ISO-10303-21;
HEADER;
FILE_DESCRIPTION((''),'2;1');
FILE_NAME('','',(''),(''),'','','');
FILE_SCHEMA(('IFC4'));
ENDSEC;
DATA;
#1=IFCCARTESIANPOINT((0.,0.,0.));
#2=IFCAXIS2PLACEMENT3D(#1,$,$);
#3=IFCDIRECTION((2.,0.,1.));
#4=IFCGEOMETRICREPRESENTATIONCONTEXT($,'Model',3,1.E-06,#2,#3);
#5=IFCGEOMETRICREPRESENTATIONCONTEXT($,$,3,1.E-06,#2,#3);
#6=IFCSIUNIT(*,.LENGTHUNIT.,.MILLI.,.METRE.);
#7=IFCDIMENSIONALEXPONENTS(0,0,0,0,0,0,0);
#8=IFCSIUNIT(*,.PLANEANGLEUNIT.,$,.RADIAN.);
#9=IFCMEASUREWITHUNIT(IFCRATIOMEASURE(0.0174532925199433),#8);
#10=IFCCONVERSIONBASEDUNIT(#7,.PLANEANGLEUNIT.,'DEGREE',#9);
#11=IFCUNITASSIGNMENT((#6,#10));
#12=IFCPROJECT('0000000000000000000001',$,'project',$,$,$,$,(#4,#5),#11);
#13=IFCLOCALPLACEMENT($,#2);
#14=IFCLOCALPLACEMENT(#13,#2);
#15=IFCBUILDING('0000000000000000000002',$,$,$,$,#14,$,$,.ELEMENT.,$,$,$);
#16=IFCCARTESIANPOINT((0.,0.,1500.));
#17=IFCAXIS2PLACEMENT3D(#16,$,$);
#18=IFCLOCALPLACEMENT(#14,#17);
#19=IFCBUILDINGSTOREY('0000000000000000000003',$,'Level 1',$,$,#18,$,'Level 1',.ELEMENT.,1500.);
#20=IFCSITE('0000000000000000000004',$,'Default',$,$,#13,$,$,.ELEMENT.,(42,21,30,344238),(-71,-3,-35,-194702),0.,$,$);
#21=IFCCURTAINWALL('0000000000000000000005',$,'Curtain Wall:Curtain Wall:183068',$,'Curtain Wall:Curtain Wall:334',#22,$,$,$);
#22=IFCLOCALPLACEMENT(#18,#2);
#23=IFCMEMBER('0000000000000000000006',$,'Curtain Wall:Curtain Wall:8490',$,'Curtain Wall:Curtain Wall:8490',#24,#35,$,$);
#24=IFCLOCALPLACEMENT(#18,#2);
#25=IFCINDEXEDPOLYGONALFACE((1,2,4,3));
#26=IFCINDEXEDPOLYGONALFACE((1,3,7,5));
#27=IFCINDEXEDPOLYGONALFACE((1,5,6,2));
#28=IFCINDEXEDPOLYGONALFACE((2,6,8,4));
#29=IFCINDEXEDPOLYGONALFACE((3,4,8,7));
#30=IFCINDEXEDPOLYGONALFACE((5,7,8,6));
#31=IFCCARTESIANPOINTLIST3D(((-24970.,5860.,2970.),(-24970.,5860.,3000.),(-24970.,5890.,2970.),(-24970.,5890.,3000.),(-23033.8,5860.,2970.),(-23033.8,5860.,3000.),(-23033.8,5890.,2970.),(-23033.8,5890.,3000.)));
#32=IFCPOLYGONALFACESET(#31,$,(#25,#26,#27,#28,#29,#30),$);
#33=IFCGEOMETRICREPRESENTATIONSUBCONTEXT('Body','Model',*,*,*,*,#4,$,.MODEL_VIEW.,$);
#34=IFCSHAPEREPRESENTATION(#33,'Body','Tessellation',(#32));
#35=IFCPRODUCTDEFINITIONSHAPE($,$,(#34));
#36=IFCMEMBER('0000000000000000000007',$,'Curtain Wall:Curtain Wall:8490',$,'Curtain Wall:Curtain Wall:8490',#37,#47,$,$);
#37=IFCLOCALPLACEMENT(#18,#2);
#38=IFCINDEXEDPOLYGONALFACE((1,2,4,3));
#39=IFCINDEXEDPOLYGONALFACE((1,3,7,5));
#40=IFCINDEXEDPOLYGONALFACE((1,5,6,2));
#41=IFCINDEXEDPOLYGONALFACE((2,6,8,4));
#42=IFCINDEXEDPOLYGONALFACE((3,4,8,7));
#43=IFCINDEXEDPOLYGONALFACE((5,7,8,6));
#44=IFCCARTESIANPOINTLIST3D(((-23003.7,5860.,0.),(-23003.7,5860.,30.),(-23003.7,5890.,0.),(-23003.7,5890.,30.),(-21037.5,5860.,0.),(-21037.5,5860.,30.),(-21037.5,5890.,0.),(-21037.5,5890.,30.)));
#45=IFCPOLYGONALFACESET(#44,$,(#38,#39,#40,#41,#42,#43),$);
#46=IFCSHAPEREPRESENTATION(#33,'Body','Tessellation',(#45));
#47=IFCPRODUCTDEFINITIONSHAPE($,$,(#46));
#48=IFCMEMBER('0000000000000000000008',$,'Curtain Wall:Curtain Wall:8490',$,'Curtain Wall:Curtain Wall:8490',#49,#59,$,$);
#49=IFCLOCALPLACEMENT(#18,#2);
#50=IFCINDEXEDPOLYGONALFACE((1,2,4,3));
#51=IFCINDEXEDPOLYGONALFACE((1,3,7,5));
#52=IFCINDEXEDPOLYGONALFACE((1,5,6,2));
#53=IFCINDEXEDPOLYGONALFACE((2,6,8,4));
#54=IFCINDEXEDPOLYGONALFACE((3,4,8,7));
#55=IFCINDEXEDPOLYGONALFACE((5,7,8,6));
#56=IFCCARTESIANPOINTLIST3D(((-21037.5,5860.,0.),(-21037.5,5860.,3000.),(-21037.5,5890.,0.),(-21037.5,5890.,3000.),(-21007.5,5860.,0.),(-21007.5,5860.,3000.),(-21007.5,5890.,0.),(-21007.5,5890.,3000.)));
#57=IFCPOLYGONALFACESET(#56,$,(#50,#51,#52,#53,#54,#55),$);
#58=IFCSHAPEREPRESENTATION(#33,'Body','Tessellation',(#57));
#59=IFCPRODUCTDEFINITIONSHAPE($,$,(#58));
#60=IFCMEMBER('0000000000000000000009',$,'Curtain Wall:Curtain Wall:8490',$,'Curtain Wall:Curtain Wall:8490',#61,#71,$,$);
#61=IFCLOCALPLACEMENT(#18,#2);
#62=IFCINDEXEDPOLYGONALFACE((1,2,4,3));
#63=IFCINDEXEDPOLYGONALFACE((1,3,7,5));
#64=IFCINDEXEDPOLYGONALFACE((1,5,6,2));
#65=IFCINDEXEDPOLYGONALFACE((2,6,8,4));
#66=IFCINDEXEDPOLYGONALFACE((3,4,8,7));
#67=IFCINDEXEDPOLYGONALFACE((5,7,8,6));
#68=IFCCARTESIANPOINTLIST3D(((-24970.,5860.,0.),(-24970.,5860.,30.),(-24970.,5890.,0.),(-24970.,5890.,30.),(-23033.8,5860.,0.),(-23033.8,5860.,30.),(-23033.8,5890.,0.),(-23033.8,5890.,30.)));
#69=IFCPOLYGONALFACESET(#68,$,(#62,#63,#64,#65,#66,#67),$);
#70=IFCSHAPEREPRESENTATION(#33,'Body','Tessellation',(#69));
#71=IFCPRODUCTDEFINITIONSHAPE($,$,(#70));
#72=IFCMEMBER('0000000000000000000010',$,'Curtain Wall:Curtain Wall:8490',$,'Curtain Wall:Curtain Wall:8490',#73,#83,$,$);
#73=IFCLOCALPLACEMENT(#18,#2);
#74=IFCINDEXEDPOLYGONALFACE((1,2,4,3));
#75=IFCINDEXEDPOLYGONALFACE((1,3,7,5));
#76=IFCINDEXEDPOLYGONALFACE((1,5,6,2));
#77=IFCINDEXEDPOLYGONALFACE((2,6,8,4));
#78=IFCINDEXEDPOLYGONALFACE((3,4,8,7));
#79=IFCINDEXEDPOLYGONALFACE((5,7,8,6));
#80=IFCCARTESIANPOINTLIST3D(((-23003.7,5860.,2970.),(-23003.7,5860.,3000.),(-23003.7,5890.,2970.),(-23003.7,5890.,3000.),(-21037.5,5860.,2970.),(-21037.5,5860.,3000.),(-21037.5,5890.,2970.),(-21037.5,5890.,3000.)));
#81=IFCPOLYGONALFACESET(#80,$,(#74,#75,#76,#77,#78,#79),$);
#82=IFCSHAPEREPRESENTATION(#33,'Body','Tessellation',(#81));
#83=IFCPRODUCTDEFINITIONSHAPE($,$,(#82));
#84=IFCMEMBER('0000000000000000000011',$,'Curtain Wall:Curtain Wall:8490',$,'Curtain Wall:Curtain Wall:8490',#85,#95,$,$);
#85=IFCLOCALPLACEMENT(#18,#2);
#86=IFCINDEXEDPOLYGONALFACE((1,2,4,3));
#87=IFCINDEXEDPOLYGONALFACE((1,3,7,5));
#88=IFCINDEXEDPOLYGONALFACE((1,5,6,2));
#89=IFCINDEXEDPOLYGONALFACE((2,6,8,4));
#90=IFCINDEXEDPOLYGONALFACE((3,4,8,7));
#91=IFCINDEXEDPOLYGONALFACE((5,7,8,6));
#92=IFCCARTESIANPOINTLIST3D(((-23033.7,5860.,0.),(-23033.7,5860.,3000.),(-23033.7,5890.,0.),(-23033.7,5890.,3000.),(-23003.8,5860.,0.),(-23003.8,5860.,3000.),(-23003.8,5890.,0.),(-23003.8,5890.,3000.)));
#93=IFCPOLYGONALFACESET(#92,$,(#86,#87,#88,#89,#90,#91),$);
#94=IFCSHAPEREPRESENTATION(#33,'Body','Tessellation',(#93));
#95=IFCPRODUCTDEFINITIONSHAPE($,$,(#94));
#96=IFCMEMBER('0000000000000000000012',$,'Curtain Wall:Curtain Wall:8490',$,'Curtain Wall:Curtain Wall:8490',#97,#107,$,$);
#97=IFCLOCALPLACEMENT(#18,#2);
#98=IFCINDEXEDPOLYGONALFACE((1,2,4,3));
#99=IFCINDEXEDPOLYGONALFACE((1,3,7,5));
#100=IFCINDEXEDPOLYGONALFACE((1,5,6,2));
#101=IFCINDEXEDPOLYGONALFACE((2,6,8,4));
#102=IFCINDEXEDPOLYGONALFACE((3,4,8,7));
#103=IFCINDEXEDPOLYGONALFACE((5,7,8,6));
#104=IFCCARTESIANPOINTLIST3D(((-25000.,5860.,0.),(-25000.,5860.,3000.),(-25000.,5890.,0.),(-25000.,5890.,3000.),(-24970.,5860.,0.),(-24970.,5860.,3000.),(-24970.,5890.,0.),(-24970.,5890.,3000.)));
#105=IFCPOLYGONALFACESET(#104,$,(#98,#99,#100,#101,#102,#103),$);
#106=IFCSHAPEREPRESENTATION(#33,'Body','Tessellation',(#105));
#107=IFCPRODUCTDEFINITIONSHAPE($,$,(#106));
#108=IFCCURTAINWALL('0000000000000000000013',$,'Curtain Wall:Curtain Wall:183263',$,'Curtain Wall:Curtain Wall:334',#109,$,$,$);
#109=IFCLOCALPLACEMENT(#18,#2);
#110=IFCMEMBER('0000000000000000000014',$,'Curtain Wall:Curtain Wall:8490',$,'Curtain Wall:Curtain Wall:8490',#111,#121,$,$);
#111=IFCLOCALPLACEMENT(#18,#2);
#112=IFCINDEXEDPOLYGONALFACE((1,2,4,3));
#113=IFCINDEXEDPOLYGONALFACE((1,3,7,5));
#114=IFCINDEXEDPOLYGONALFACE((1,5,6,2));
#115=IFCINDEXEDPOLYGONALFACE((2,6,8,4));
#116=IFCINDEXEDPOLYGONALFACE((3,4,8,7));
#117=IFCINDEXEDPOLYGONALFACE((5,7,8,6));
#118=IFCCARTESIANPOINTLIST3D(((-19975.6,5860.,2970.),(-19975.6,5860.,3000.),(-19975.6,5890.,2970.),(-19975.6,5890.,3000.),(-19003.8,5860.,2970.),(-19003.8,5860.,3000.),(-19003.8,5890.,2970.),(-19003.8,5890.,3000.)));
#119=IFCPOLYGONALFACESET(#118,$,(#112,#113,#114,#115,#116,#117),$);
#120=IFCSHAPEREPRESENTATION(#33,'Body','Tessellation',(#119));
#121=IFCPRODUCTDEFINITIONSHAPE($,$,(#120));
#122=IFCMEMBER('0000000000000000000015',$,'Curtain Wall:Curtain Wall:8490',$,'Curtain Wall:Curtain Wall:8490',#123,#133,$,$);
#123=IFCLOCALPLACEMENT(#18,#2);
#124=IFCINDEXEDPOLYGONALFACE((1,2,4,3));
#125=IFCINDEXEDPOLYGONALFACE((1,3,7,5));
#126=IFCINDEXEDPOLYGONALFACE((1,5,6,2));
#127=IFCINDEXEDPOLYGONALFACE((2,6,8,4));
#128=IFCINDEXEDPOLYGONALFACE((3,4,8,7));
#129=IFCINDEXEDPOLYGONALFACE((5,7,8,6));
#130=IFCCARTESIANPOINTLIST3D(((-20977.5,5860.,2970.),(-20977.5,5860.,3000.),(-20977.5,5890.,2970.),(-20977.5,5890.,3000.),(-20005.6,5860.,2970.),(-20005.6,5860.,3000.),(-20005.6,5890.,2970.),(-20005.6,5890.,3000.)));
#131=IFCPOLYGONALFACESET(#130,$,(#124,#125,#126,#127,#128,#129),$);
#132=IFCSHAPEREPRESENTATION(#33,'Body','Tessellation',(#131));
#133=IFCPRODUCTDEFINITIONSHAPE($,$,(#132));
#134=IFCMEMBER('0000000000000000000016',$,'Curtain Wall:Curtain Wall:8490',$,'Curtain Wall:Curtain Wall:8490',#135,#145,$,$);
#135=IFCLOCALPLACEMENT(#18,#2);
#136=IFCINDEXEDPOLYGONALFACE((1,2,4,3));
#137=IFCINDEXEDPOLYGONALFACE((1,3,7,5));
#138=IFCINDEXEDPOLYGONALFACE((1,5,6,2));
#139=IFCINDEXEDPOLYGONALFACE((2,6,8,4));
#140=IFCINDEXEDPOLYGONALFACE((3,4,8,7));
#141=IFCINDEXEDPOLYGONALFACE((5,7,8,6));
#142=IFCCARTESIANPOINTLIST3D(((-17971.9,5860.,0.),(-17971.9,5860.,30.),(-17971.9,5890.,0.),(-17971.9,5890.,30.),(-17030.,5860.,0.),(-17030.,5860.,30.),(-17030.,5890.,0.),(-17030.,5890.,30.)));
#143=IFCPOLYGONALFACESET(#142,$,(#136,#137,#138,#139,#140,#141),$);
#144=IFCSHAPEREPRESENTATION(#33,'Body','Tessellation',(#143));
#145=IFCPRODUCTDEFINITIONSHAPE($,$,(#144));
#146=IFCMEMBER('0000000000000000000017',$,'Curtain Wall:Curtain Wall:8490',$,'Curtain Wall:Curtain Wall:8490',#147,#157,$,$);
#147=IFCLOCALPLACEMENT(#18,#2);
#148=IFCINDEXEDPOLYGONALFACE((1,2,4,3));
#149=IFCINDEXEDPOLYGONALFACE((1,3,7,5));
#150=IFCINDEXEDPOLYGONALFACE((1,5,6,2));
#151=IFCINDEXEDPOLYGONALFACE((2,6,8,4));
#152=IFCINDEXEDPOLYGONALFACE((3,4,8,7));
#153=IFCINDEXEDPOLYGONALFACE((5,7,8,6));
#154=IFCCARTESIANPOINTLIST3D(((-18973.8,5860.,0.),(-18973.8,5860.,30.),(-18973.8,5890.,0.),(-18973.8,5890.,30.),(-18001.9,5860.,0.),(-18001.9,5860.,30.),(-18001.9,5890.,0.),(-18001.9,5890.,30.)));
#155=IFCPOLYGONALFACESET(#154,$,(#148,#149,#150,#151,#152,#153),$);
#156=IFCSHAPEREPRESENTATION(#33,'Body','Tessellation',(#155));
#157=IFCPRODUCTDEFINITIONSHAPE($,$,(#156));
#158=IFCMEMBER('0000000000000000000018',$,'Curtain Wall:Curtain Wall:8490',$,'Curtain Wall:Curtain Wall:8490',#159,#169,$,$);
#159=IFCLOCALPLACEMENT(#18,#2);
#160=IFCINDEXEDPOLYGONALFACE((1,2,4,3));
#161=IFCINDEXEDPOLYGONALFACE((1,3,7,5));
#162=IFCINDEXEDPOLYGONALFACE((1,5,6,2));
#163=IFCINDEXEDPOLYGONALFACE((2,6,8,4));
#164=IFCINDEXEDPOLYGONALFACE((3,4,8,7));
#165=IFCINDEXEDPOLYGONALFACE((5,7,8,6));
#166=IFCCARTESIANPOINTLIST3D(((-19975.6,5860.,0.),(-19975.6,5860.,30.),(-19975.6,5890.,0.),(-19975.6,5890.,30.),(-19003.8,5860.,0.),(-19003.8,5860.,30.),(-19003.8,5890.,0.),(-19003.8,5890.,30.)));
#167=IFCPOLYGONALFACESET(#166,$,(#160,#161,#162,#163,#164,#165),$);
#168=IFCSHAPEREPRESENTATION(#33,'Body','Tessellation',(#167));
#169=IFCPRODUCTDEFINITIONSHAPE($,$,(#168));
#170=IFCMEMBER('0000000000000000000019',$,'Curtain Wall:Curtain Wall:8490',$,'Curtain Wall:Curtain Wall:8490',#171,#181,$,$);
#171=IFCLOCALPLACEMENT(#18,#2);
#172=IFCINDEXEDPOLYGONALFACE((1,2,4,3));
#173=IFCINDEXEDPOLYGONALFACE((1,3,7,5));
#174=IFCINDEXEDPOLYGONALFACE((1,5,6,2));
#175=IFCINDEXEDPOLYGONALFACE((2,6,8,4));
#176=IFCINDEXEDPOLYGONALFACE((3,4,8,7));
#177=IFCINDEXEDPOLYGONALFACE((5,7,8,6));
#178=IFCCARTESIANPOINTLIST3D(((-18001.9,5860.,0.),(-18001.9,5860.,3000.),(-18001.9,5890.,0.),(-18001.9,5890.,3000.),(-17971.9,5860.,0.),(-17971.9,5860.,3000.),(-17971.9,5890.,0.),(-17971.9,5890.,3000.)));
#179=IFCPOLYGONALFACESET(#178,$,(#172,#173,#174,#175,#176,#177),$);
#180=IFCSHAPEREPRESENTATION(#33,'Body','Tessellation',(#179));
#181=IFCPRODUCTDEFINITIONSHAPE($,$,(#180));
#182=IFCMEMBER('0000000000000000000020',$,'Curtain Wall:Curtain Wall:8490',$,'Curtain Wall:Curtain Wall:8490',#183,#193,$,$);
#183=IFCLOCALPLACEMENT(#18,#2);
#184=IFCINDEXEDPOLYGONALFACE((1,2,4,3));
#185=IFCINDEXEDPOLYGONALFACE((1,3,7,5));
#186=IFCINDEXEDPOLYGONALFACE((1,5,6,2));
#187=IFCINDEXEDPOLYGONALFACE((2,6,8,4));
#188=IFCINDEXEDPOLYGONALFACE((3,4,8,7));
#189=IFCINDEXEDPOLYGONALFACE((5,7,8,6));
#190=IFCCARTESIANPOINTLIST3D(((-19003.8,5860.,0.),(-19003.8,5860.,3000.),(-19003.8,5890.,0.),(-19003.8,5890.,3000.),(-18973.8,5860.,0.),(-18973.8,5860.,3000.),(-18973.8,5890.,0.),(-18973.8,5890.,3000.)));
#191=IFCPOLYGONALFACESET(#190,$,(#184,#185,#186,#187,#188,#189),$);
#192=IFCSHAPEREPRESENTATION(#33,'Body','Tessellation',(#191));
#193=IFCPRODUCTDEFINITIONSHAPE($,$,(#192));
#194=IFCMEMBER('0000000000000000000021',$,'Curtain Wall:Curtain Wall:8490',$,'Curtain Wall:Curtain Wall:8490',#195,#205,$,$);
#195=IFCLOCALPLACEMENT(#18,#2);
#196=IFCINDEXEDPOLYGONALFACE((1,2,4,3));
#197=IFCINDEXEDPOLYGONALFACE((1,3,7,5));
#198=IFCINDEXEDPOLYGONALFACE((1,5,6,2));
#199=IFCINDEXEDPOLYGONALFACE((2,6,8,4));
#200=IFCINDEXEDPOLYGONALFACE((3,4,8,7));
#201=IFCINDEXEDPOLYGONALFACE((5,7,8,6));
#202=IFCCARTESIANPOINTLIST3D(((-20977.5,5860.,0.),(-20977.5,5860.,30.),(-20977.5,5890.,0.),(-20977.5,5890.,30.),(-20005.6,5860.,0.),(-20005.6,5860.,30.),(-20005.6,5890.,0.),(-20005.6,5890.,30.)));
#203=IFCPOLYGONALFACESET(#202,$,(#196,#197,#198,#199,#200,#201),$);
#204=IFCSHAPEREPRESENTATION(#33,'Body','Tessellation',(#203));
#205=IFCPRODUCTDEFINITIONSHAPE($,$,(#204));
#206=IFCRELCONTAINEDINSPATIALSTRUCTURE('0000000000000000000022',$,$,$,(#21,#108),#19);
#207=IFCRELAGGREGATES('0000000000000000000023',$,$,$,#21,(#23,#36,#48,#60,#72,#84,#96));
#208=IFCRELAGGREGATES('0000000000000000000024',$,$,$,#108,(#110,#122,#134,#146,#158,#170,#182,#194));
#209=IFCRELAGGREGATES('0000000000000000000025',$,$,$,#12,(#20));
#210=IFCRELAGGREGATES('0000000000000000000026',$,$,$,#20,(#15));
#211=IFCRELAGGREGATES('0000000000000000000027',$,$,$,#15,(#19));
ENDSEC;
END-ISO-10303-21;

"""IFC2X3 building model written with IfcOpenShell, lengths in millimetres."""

from ifc_helpers import new_model, entity, si_unit, converted_unit, direction, frame, frame_2d, origin, origin_2d_with_axis, place, context, subcontext, project, spatial, rectangle, extrude, element, aggregate, save


model = new_model("IFC2X3")

# Units and contexts
model_context = context("Model", 3, precision=1e-06, world=origin(), true_north=direction((2.0, 0.0, 1.0)))
context_of_model = context(None, 3, precision=1e-06, world=origin(), true_north=direction((2.0, 0.0, 1.0)))
body_context = subcontext(model_context, "Body", "Model", "MODEL_VIEW")
ifc_project = project(units=[si_unit("LENGTHUNIT", "METRE", prefix="MILLI"), converted_unit("PLANEANGLEUNIT", "DEGREE", entity("IfcRatioMeasure", 0.0174532925199433), si_unit("PLANEANGLEUNIT", "RADIAN"), dimensions=[0, 0, 0, 0, 0, 0, 0])], contexts=[model_context, context_of_model])

# Site, building, storey
site_placement = place(None, origin())
site = spatial("IfcSite", under=ifc_project, at=site_placement, Name="Default", CompositionType="ELEMENT", RefLatitude=(42, 21, 30, 344238), RefLongitude=(-71, -3, -35, -194702), RefElevation=0.0)
building_placement = place(site_placement, origin())
building = spatial("IfcBuilding", under=site, at=building_placement, CompositionType="ELEMENT")
storey_placement = place(building_placement, frame((0.0, 0.0, 1500.0)))
storey = spatial("IfcBuildingStorey", under=building, at=storey_placement, Name="Level 1", LongName="Level 1", CompositionType="ELEMENT", Elevation=1500.0)

# Curtain walls, members
curtain_wall_1_placement = place(storey_placement, origin())
curtain_wall_1 = element("IfcCurtainWall", 1, at=curtain_wall_1_placement, inside=storey, Name="Curtain Wall:Curtain Wall:183068", ObjectType="Curtain Wall:Curtain Wall:334")
member_1_placement = place(storey_placement, origin())
member_1 = element("IfcMember", 2, at=member_1_placement, Name="Curtain Wall:Curtain Wall:8490", ObjectType="Curtain Wall:Curtain Wall:8490", context=body_context, shape_type="SweptSolid", body=[
    extrude(rectangle(XDim=1936.2, YDim=30.0, at=origin_2d_with_axis()), frame((-24001.9, 5875.0, 2970.0), z_axis=(0.0, 0.0, 1.0), x_axis=(-1.0, 0.0, 0.0)), (0.0, 0.0, 1.0), 30.0),
])
member_2_placement = place(storey_placement, origin())
member_2 = element("IfcMember", 3, at=member_2_placement, Name="Curtain Wall:Curtain Wall:8490", ObjectType="Curtain Wall:Curtain Wall:8490", context=body_context, shape_type="SweptSolid", body=[
    extrude(rectangle(XDim=1966.2, YDim=30.0, at=frame_2d((0.0, 0.0), x_axis=(1.0, 0.0))), frame((-22020.6, 5875.0, 0.0)), (0.0, 0.0, 1.0), 30.0),
])
member_3_placement = place(storey_placement, origin())
member_3 = element("IfcMember", 4, at=member_3_placement, Name="Curtain Wall:Curtain Wall:8490", ObjectType="Curtain Wall:Curtain Wall:8490", context=body_context, shape_type="SweptSolid", body=[
    extrude(rectangle(XDim=30.0, YDim=30.0, at=frame_2d((0.0, 0.0), x_axis=(1.0, 0.0))), frame((-21022.5, 5875.0, 0.0), z_axis=(0.0, 0.0, 1.0), x_axis=(0.0, 1.0, 0.0)), (0.0, 0.0, 1.0), 3000.0),
])
member_4_placement = place(storey_placement, origin())
member_4 = element("IfcMember", 5, at=member_4_placement, Name="Curtain Wall:Curtain Wall:8490", ObjectType="Curtain Wall:Curtain Wall:8490", context=body_context, shape_type="SweptSolid", body=[
    extrude(rectangle(XDim=1936.2, YDim=30.0, at=origin_2d_with_axis()), frame((-24001.9, 5875.0, 0.0)), (0.0, 0.0, 1.0), 30.0),
])
member_5_placement = place(storey_placement, origin())
member_5 = element("IfcMember", 6, at=member_5_placement, Name="Curtain Wall:Curtain Wall:8490", ObjectType="Curtain Wall:Curtain Wall:8490", context=body_context, shape_type="SweptSolid", body=[
    extrude(rectangle(XDim=1966.2, YDim=30.0, at=frame_2d((0.0, 0.0), x_axis=(1.0, 0.0))), frame((-22020.6, 5875.0, 2970.0), z_axis=(0.0, 0.0, 1.0), x_axis=(-1.0, 0.0, 0.0)), (0.0, 0.0, 1.0), 30.0),
])
member_6_placement = place(storey_placement, origin())
member_6 = element("IfcMember", 7, at=member_6_placement, Name="Curtain Wall:Curtain Wall:8490", ObjectType="Curtain Wall:Curtain Wall:8490", context=body_context, shape_type="SweptSolid", body=[
    extrude(rectangle(XDim=30.0, YDim=30.0, at=frame_2d((0.0, 0.0), x_axis=(1.0, 0.0))), frame((-23018.8, 5875.0, 0.0), z_axis=(0.0, 0.0, 1.0), x_axis=(0.0, 1.0, 0.0)), (0.0, 0.0, 1.0), 3000.0),
])
member_7_placement = place(storey_placement, origin())
member_7 = element("IfcMember", 8, at=member_7_placement, Name="Curtain Wall:Curtain Wall:8490", ObjectType="Curtain Wall:Curtain Wall:8490", context=body_context, shape_type="SweptSolid", body=[
    extrude(rectangle(XDim=30.0, YDim=30.0, at=origin_2d_with_axis()), frame((-24985.0, 5875.0, 0.0)), (0.0, 0.0, 1.0), 3000.0),
])
curtain_wall_2_placement = place(storey_placement, origin())
curtain_wall_2 = element("IfcCurtainWall", 9, at=curtain_wall_2_placement, inside=storey, Name="Curtain Wall:Curtain Wall:183263", ObjectType="Curtain Wall:Curtain Wall:334")
member_8_placement = place(storey_placement, origin())
member_8 = element("IfcMember", 10, at=member_8_placement, Name="Curtain Wall:Curtain Wall:8490", ObjectType="Curtain Wall:Curtain Wall:8490", context=body_context, shape_type="SweptSolid", body=[
    extrude(rectangle(XDim=971.9, YDim=30.0, at=frame_2d((0.0, 0.0), x_axis=(1.0, 0.0))), frame((-19489.7, 5875.0, 2970.0), z_axis=(0.0, 0.0, 1.0), x_axis=(-1.0, 0.0, 0.0)), (0.0, 0.0, 1.0), 30.0),
])
member_9_placement = place(storey_placement, origin())
member_9 = element("IfcMember", 11, at=member_9_placement, Name="Curtain Wall:Curtain Wall:8490", ObjectType="Curtain Wall:Curtain Wall:8490", context=body_context, shape_type="SweptSolid", body=[
    extrude(rectangle(XDim=971.9, YDim=30.0, at=frame_2d((0.0, 0.0), x_axis=(1.0, 0.0))), frame((-20491.6, 5875.0, 2970.0), z_axis=(0.0, 0.0, 1.0), x_axis=(-1.0, 0.0, 0.0)), (0.0, 0.0, 1.0), 30.0),
])
member_10_placement = place(storey_placement, origin())
member_10 = element("IfcMember", 12, at=member_10_placement, Name="Curtain Wall:Curtain Wall:8490", ObjectType="Curtain Wall:Curtain Wall:8490", context=body_context, shape_type="SweptSolid", body=[
    extrude(rectangle(XDim=941.9, YDim=30.0, at=frame_2d((0.0, 0.0), x_axis=(1.0, 0.0))), frame((-17500.9, 5875.0, 0.0)), (0.0, 0.0, 1.0), 30.0),
])
member_11_placement = place(storey_placement, origin())
member_11 = element("IfcMember", 13, at=member_11_placement, Name="Curtain Wall:Curtain Wall:8490", ObjectType="Curtain Wall:Curtain Wall:8490", context=body_context, shape_type="SweptSolid", body=[
    extrude(rectangle(XDim=971.9, YDim=30.0, at=frame_2d((0.0, 0.0), x_axis=(1.0, 0.0))), frame((-18487.8, 5875.0, 0.0)), (0.0, 0.0, 1.0), 30.0),
])
member_12_placement = place(storey_placement, origin())
member_12 = element("IfcMember", 14, at=member_12_placement, Name="Curtain Wall:Curtain Wall:8490", ObjectType="Curtain Wall:Curtain Wall:8490", context=body_context, shape_type="SweptSolid", body=[
    extrude(rectangle(XDim=971.9, YDim=30.0, at=frame_2d((0.0, 0.0), x_axis=(1.0, 0.0))), frame((-19489.7, 5875.0, 0.0)), (0.0, 0.0, 1.0), 30.0),
])
member_13_placement = place(storey_placement, origin())
member_13 = element("IfcMember", 15, at=member_13_placement, Name="Curtain Wall:Curtain Wall:8490", ObjectType="Curtain Wall:Curtain Wall:8490", context=body_context, shape_type="SweptSolid", body=[
    extrude(rectangle(XDim=30.0, YDim=30.0, at=frame_2d((0.0, 0.0), x_axis=(1.0, 0.0))), frame((-17986.9, 5875.0, 0.0), z_axis=(0.0, 0.0, 1.0), x_axis=(0.0, 1.0, 0.0)), (0.0, 0.0, 1.0), 3000.0),
])
member_14_placement = place(storey_placement, origin())
member_14 = element("IfcMember", 16, at=member_14_placement, Name="Curtain Wall:Curtain Wall:8490", ObjectType="Curtain Wall:Curtain Wall:8490", context=body_context, shape_type="SweptSolid", body=[
    extrude(rectangle(XDim=30.0, YDim=30.0, at=frame_2d((0.0, 0.0), x_axis=(1.0, 0.0))), frame((-18988.8, 5875.0, 0.0), z_axis=(0.0, 0.0, 1.0), x_axis=(0.0, 1.0, 0.0)), (0.0, 0.0, 1.0), 3000.0),
])
member_15_placement = place(storey_placement, origin())
member_15 = element("IfcMember", 17, at=member_15_placement, Name="Curtain Wall:Curtain Wall:8490", ObjectType="Curtain Wall:Curtain Wall:8490", context=body_context, shape_type="SweptSolid", body=[
    extrude(rectangle(XDim=971.9, YDim=30.0, at=frame_2d((0.0, 0.0), x_axis=(1.0, 0.0))), frame((-20491.6, 5875.0, 0.0)), (0.0, 0.0, 1.0), 30.0),
])

aggregate(curtain_wall_1, [member_1, member_2, member_3, member_4, member_5, member_6, member_7])
aggregate(curtain_wall_2, [member_8, member_9, member_10, member_11, member_12, member_13, member_14, member_15])

save(model, "model.ifc")
